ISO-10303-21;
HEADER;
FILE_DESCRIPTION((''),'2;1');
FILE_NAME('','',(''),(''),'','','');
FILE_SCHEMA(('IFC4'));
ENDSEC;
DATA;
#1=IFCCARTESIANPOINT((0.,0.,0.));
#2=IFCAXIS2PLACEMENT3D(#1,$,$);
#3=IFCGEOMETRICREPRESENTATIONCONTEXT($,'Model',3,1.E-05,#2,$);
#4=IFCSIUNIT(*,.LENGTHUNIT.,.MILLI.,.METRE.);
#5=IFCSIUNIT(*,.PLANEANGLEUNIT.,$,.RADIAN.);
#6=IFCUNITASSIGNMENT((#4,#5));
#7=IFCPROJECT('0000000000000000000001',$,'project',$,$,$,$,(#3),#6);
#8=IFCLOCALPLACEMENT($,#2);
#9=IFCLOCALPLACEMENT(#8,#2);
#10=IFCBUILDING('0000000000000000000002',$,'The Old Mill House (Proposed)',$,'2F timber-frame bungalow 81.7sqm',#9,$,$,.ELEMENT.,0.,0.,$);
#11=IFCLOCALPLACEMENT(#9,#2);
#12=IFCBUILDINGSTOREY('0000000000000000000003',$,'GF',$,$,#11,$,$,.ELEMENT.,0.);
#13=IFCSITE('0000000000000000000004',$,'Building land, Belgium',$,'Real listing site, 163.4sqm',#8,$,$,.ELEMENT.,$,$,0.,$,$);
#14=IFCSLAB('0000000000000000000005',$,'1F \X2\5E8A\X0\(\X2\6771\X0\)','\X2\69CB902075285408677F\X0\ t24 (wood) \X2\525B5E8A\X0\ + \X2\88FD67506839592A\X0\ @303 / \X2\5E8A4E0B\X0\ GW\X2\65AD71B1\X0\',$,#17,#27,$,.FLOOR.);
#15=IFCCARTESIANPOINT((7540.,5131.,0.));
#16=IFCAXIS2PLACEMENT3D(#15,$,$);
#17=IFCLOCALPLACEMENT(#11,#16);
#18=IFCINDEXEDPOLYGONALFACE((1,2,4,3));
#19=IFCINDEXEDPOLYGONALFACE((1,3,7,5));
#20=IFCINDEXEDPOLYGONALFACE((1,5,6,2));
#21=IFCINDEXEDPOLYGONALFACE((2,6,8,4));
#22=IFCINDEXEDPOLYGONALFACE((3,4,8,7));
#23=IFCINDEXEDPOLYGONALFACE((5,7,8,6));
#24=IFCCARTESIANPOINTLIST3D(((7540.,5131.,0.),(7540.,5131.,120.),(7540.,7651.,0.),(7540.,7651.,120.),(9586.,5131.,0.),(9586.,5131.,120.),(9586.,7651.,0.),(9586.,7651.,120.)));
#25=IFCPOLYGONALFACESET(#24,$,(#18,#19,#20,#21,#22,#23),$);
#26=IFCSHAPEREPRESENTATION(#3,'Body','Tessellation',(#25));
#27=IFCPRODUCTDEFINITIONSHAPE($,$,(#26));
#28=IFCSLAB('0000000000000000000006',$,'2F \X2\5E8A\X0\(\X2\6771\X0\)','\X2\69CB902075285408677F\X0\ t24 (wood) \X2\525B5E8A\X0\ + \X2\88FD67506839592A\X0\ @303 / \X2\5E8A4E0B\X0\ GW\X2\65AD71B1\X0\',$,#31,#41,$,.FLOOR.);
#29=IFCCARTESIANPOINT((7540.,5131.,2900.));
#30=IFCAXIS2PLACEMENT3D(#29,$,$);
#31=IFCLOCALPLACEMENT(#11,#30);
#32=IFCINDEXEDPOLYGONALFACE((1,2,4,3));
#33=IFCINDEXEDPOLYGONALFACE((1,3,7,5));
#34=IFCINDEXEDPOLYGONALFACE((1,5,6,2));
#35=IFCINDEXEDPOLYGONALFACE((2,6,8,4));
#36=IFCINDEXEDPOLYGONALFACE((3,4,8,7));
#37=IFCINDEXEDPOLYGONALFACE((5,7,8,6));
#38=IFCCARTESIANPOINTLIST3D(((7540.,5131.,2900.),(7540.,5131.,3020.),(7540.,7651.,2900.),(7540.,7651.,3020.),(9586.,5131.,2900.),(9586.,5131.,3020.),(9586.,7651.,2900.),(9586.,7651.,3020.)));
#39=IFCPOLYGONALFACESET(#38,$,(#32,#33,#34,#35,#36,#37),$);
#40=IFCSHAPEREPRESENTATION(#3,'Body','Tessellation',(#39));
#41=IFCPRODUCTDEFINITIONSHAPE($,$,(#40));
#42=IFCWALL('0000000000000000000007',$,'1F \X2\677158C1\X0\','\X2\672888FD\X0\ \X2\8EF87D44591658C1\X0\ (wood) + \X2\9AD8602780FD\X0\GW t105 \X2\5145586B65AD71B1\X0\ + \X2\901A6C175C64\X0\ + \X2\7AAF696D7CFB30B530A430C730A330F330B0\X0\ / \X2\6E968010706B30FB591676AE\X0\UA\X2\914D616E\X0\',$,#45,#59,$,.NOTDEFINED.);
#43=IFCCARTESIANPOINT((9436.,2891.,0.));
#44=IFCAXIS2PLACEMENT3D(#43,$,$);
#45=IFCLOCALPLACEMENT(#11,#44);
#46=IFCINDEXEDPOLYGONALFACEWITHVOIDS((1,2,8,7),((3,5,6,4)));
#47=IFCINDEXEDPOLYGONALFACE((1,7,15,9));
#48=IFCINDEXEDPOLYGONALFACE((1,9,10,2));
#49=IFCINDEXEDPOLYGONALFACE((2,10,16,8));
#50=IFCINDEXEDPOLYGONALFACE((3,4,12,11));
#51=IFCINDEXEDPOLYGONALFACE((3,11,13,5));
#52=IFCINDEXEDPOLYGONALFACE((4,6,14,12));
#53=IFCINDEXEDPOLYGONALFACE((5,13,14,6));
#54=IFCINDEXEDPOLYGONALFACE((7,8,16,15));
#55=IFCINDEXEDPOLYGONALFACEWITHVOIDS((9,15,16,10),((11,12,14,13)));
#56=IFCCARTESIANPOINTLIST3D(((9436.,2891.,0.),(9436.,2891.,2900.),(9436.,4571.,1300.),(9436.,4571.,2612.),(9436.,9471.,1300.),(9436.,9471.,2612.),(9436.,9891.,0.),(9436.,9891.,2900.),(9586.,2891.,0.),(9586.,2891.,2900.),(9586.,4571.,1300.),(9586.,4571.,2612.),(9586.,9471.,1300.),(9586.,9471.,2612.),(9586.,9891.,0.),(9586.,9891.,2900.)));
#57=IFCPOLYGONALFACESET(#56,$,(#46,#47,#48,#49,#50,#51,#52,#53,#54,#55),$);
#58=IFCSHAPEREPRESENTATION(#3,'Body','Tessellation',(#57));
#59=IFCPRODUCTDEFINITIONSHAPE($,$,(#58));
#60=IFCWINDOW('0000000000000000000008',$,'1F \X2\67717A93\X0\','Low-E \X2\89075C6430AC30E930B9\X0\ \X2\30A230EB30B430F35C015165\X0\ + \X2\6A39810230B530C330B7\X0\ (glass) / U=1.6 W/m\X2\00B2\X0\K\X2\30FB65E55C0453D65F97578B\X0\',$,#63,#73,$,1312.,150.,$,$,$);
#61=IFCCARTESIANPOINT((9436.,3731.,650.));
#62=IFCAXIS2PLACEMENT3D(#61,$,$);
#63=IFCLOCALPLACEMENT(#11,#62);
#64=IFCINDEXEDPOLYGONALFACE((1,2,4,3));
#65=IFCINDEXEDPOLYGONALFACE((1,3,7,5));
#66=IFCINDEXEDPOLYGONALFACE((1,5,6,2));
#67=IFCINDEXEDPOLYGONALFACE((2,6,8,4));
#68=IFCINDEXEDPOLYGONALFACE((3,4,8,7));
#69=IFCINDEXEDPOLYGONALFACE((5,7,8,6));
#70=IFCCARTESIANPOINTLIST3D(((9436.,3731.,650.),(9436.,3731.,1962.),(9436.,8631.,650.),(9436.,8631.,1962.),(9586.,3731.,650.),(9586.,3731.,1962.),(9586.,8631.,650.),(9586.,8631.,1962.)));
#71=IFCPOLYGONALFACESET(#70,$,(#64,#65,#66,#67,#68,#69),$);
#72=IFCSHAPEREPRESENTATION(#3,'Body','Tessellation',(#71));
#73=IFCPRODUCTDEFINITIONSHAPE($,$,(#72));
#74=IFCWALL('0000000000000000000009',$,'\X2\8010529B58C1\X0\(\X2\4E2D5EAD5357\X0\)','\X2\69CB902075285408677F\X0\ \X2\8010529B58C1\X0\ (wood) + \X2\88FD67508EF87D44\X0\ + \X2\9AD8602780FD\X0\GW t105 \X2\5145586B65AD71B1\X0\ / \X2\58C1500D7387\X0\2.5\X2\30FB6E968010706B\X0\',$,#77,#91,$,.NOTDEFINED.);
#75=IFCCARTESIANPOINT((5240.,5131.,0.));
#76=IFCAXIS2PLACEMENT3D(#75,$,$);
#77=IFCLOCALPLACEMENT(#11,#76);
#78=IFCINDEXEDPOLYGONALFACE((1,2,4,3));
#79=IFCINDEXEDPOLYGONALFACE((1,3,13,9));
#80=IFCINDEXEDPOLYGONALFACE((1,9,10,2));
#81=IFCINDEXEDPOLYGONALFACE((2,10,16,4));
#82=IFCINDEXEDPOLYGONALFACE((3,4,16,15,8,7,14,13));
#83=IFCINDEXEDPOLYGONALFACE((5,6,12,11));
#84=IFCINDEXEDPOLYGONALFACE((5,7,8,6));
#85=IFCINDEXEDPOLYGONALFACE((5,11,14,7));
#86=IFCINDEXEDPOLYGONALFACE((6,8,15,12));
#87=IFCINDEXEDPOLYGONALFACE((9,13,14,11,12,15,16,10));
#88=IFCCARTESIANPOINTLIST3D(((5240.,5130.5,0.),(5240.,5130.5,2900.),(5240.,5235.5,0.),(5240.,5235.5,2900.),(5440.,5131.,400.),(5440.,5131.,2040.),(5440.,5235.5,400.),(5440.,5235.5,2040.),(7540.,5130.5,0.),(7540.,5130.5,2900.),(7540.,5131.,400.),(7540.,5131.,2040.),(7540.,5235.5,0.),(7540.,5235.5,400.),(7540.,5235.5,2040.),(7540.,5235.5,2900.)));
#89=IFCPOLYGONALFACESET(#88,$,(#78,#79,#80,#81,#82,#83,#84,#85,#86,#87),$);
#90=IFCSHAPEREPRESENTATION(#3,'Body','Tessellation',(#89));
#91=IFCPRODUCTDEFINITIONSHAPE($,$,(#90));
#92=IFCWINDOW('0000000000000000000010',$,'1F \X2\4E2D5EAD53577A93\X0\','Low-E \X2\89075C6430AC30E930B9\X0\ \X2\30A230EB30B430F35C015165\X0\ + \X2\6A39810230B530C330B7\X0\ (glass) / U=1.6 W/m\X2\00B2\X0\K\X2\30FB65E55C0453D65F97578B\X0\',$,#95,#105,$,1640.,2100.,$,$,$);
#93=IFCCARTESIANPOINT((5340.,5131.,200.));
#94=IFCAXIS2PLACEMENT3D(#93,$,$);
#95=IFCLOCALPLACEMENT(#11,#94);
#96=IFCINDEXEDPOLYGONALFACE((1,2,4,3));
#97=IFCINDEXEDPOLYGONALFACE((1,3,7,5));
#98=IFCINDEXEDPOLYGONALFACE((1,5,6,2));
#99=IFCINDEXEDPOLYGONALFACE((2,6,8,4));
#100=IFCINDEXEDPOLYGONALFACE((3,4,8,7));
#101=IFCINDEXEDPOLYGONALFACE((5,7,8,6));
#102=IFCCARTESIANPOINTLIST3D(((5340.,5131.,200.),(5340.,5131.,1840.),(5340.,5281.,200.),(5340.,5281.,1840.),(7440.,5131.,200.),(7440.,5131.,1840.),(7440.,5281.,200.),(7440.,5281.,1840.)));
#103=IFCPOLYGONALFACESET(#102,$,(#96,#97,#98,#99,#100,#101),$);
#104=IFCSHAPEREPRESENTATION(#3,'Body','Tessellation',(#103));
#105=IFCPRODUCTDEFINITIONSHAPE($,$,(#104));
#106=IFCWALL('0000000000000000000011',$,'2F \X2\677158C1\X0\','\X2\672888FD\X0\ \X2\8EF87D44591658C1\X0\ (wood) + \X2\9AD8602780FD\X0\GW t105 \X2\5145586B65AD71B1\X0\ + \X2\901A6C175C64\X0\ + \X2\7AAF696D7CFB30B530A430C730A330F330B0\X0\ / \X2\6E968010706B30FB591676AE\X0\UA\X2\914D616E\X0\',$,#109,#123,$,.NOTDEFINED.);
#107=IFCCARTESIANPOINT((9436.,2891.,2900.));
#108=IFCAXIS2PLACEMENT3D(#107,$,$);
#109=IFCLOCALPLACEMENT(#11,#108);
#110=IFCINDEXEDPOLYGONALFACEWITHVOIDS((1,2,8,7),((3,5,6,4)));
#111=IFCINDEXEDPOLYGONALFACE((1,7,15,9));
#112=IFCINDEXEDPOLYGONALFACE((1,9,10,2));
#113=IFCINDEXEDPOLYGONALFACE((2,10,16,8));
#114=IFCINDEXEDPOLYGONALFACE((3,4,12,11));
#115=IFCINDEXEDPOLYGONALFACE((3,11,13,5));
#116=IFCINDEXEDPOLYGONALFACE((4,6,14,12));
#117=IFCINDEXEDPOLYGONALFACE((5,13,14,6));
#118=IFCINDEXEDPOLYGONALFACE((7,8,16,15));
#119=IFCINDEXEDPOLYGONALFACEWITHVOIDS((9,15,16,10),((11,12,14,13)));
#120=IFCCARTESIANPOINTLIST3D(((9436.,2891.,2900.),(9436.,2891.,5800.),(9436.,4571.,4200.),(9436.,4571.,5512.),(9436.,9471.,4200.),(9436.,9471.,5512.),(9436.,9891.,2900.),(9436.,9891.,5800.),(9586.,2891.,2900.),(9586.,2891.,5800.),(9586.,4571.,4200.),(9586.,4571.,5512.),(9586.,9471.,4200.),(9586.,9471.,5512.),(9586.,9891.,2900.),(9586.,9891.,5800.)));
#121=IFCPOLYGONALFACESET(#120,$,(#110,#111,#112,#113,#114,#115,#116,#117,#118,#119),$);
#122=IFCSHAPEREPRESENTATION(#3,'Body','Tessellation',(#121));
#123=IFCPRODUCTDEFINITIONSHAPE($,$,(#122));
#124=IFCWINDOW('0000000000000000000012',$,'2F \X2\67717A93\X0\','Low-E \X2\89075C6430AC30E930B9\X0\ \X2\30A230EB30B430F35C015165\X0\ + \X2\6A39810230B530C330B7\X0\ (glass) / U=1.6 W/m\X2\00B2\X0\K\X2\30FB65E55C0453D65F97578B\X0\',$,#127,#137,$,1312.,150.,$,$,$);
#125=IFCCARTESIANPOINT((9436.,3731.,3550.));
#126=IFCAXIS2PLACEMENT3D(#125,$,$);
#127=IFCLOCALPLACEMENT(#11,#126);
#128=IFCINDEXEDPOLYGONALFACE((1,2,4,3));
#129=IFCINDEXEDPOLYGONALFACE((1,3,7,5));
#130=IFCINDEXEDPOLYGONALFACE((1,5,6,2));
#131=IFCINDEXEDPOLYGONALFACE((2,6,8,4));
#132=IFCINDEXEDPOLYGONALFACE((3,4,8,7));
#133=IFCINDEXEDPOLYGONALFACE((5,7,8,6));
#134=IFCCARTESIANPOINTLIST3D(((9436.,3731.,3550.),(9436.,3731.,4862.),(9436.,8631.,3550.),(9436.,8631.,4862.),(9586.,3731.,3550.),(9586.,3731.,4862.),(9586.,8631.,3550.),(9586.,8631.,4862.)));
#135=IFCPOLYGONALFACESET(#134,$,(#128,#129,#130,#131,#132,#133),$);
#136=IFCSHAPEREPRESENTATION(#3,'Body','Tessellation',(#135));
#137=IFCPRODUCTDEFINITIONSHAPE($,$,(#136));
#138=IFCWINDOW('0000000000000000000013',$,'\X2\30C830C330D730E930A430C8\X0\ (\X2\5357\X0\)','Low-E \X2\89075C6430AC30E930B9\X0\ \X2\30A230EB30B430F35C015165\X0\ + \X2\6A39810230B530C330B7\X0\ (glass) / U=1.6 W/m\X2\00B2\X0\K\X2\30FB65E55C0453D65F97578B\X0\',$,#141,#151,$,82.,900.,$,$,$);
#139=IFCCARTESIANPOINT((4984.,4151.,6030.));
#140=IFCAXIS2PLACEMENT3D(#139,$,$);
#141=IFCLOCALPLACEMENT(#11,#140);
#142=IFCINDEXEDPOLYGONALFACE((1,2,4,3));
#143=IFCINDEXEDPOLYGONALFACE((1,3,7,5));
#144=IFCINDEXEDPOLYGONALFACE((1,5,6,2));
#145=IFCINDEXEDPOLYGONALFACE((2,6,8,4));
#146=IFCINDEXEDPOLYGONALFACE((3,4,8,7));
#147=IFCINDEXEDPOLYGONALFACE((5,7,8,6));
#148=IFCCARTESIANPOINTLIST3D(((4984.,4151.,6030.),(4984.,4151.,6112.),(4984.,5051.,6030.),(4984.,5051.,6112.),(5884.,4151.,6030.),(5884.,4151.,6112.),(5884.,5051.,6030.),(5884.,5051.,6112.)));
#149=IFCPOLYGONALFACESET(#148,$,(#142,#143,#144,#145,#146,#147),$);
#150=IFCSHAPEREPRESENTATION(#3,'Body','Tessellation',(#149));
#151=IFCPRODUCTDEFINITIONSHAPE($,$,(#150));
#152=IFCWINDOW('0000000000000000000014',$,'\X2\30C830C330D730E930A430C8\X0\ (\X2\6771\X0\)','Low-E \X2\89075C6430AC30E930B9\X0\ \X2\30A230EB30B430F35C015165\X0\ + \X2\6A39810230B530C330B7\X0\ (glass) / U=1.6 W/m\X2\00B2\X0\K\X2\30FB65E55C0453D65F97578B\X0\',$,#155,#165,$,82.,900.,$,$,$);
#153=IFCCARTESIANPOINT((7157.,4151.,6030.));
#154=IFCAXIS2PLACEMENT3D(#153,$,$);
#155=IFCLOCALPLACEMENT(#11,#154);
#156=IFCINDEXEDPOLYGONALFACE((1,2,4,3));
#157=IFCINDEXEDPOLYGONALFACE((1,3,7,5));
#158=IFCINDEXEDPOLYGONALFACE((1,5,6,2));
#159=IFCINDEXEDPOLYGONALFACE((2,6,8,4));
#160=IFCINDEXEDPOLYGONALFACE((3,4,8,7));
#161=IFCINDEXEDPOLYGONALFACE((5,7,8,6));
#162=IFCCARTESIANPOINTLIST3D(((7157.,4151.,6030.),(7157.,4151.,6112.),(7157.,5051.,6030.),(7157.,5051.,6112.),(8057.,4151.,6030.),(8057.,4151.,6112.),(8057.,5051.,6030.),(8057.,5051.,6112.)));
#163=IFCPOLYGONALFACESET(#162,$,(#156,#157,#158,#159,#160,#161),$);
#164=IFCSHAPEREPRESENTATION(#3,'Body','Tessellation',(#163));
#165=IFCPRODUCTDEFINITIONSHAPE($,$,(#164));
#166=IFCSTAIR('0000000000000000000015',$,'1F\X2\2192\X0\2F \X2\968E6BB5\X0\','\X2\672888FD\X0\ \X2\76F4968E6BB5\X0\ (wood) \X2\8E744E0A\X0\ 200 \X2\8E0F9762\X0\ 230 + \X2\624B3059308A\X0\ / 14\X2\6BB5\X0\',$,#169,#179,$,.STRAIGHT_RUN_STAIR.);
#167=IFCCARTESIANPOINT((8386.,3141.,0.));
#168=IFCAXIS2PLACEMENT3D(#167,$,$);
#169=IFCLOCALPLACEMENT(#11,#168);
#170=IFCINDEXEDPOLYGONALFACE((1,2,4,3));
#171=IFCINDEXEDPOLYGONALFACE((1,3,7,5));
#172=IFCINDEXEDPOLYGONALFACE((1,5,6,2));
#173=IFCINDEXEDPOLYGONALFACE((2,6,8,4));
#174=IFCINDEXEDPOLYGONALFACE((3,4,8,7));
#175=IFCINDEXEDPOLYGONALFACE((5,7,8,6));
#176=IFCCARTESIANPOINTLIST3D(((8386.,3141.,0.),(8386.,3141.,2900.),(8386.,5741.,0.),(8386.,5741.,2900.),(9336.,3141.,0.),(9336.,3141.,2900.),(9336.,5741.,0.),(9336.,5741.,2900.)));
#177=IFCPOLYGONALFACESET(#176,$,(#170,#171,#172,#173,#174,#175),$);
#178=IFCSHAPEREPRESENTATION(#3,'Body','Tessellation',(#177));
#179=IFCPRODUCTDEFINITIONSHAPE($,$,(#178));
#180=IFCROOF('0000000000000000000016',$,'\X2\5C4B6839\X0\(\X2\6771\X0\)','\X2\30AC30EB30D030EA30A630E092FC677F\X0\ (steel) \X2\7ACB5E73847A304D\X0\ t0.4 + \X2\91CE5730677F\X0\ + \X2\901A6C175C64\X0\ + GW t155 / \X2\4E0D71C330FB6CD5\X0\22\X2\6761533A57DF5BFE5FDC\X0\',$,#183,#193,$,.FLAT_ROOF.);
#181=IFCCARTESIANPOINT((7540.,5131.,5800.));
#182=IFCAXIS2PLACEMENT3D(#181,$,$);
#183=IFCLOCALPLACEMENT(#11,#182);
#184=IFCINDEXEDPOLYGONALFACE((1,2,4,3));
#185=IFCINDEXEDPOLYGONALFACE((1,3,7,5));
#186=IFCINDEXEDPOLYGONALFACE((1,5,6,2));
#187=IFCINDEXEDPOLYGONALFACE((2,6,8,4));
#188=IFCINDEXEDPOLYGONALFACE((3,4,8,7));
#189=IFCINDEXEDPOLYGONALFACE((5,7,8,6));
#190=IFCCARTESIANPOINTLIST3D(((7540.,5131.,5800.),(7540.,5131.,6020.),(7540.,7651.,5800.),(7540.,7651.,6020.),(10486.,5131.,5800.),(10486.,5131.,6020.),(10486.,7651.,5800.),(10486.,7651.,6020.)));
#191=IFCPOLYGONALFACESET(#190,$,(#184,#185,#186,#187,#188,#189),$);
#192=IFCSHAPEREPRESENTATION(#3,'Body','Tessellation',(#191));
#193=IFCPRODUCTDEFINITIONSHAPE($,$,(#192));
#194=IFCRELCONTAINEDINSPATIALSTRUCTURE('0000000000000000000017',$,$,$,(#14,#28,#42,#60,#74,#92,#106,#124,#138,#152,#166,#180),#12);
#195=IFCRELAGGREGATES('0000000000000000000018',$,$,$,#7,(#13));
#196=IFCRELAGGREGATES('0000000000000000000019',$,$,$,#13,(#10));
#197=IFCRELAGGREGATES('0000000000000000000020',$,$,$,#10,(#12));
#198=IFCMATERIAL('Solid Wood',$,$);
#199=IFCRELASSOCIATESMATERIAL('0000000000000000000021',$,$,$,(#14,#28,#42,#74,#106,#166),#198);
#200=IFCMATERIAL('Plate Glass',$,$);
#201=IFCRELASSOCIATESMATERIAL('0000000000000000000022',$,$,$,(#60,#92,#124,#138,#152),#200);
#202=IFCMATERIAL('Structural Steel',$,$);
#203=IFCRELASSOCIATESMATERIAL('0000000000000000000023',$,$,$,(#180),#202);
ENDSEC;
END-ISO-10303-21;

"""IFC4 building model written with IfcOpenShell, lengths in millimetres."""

from ifc_helpers import new_model, si_unit, frame, frame_2d, origin, place, context, project, spatial, rectangle, extrude, material, element, fill, save


model = new_model("IFC4")

# Units and contexts
model_context = context("Model", 3, precision=1e-05, world=origin())
ifc_project = project(units=[si_unit("LENGTHUNIT", "METRE", prefix="MILLI"), si_unit("PLANEANGLEUNIT", "RADIAN")], contexts=[model_context])

# Site, building, storey
site_placement = place(None, origin())
site = spatial("IfcSite", under=ifc_project, at=site_placement, Name="Building land, Belgium", ObjectType="Real listing site, 163.4sqm", CompositionType="ELEMENT", RefElevation=0.0)
building_placement = place(site_placement, origin())
building = spatial("IfcBuilding", under=site, at=building_placement, Name="The Old Mill House (Proposed)", ObjectType="2F timber-frame bungalow 81.7sqm", CompositionType="ELEMENT", ElevationOfRefHeight=0.0, ElevationOfTerrain=0.0)
storey_placement = place(building_placement, origin())
storey = spatial("IfcBuildingStorey", under=building, at=storey_placement, Name="GF", CompositionType="ELEMENT", Elevation=0.0)

# Slabs
ifc_material_1 = material(Name="Solid Wood")
slab_1_placement = place(storey_placement, frame((7540.0, 5131.0, 0.0)))
element("IfcSlab", 1, at=slab_1_placement, inside=storey, material=ifc_material_1, Name="1F 床(東)", Description="構造用合板 t24 (wood) 剛床 + 製材根太 @303 / 床下 GW断熱", PredefinedType="FLOOR", context=model_context, shape_type="SweptSolid", body=[
    extrude(rectangle(XDim=2046.0, YDim=2520.0, at=frame_2d((1023.0, 1260.0))), frame((7540.0, 5131.0, 0.0)), (0.0, 0.0, 1.0), 120.0),
])
slab_2_placement = place(storey_placement, frame((7540.0, 5131.0, 2900.0)))
element("IfcSlab", 2, at=slab_2_placement, inside=storey, material=ifc_material_1, Name="2F 床(東)", Description="構造用合板 t24 (wood) 剛床 + 製材根太 @303 / 床下 GW断熱", PredefinedType="FLOOR", context=model_context, shape_type="SweptSolid", body=[
    extrude(rectangle(XDim=2046.0, YDim=2520.0, at=frame_2d((1023.0, 1260.0))), frame((7540.0, 5131.0, 2900.0)), (0.0, 0.0, 1.0), 120.0),
])

# Walls, openings, windows
wall_1_placement = place(storey_placement, frame((9436.0, 2891.0, 0.0)))
wall_1 = element("IfcWall", 3, at=wall_1_placement, inside=storey, material=ifc_material_1, Name="1F 東壁", Description="木製 軸組外壁 (wood) + 高性能GW t105 充填断熱 + 通気層 + 窯業系サイディング / 準耐火・外皮UA配慮", PredefinedType="NOTDEFINED", context=model_context, shape_type="SweptSolid", body=[
    extrude(rectangle(XDim=150.0, YDim=7000.0, at=frame_2d((75.0, 3500.0))), frame((9436.0, 2891.0, 0.0)), (0.0, 0.0, 1.0), 2900.0),
])
opening_1_placement = place(storey_placement, frame((9436.0, 3731.0, 650.0)))
opening_1 = element("IfcOpeningElement", 4, at=opening_1_placement, cuts=wall_1, PredefinedType="NOTDEFINED", context=model_context, shape_type="SweptSolid", body=[
    extrude(rectangle(XDim=150.0, YDim=4900.0, at=frame_2d((75.0, 2450.0))), frame((9436.0, 3731.0, 650.0)), (0.0, 0.0, 1.0), 1312.0),
])
ifc_material_2 = material(Name="Plate Glass")
window_1_placement = place(storey_placement, frame((9436.0, 3731.0, 650.0)))
window_1 = element("IfcWindow", 5, at=window_1_placement, inside=storey, material=ifc_material_2, Name="1F 東窓", Description="Low-E 複層ガラス アルゴン封入 + 樹脂サッシ (glass) / U=1.6 W/m²K・日射取得型", OverallHeight=1312.0, OverallWidth=150.0, context=model_context, shape_type="SweptSolid", body=[
    extrude(rectangle(XDim=150.0, YDim=4900.0, at=frame_2d((75.0, 2450.0))), frame((9436.0, 3731.0, 650.0)), (0.0, 0.0, 1.0), 1312.0),
])
fill(opening_1, window_1)
wall_2_placement = place(storey_placement, frame((5240.0, 5131.0, 0.0)))
wall_2 = element("IfcWall", 6, at=wall_2_placement, inside=storey, material=ifc_material_1, Name="耐力壁(中庭南)", Description="構造用合板 耐力壁 (wood) + 製材軸組 + 高性能GW t105 充填断熱 / 壁倍率2.5・準耐火", PredefinedType="NOTDEFINED", context=model_context, shape_type="SweptSolid", body=[
    extrude(rectangle(XDim=2300.0, YDim=105.0, at=frame_2d((1150.0, 52.0))), frame((5240.0, 5131.0, 0.0)), (0.0, 0.0, 1.0), 2900.0),
])
opening_2_placement = place(storey_placement, frame((5340.0, 5131.0, 200.0)))
opening_2 = element("IfcOpeningElement", 7, at=opening_2_placement, cuts=wall_2, PredefinedType="NOTDEFINED", context=model_context, shape_type="SweptSolid", body=[
    extrude(rectangle(XDim=2100.0, YDim=150.0, at=frame_2d((1050.0, 75.0))), frame((5340.0, 5131.0, 200.0)), (0.0, 0.0, 1.0), 1640.0),
])
window_2_placement = place(storey_placement, frame((5340.0, 5131.0, 200.0)))
window_2 = element("IfcWindow", 8, at=window_2_placement, inside=storey, material=ifc_material_2, Name="1F 中庭南窓", Description="Low-E 複層ガラス アルゴン封入 + 樹脂サッシ (glass) / U=1.6 W/m²K・日射取得型", OverallHeight=1640.0, OverallWidth=2100.0, context=model_context, shape_type="SweptSolid", body=[
    extrude(rectangle(XDim=2100.0, YDim=150.0, at=frame_2d((1050.0, 75.0))), frame((5340.0, 5131.0, 200.0)), (0.0, 0.0, 1.0), 1640.0),
])
fill(opening_2, window_2)

# Wall, opening, window
wall_3_placement = place(storey_placement, frame((9436.0, 2891.0, 2900.0)))
wall_3 = element("IfcWall", 9, at=wall_3_placement, inside=storey, material=ifc_material_1, Name="2F 東壁", Description="木製 軸組外壁 (wood) + 高性能GW t105 充填断熱 + 通気層 + 窯業系サイディング / 準耐火・外皮UA配慮", PredefinedType="NOTDEFINED", context=model_context, shape_type="SweptSolid", body=[
    extrude(rectangle(XDim=150.0, YDim=7000.0, at=frame_2d((75.0, 3500.0))), frame((9436.0, 2891.0, 2900.0)), (0.0, 0.0, 1.0), 2900.0),
])
opening_3_placement = place(storey_placement, frame((9436.0, 3731.0, 3550.0)))
opening_3 = element("IfcOpeningElement", 10, at=opening_3_placement, cuts=wall_3, PredefinedType="NOTDEFINED", context=model_context, shape_type="SweptSolid", body=[
    extrude(rectangle(XDim=150.0, YDim=4900.0, at=frame_2d((75.0, 2450.0))), frame((9436.0, 3731.0, 3550.0)), (0.0, 0.0, 1.0), 1312.0),
])
window_3_placement = place(storey_placement, frame((9436.0, 3731.0, 3550.0)))
window_3 = element("IfcWindow", 11, at=window_3_placement, inside=storey, material=ifc_material_2, Name="2F 東窓", Description="Low-E 複層ガラス アルゴン封入 + 樹脂サッシ (glass) / U=1.6 W/m²K・日射取得型", OverallHeight=1312.0, OverallWidth=150.0, context=model_context, shape_type="SweptSolid", body=[
    extrude(rectangle(XDim=150.0, YDim=4900.0, at=frame_2d((75.0, 2450.0))), frame((9436.0, 3731.0, 3550.0)), (0.0, 0.0, 1.0), 1312.0),
])
fill(opening_3, window_3)

# Windows
window_4_placement = place(storey_placement, frame((4984.0, 4151.0, 6030.0)))
element("IfcWindow", 12, at=window_4_placement, inside=storey, material=ifc_material_2, Name="トップライト (南)", Description="Low-E 複層ガラス アルゴン封入 + 樹脂サッシ (glass) / U=1.6 W/m²K・日射取得型", OverallHeight=82.0, OverallWidth=900.0, context=model_context, shape_type="SweptSolid", body=[
    extrude(rectangle(XDim=900.0, YDim=900.0, at=frame_2d((450.0, 450.0))), frame((4984.0, 4151.0, 6030.0)), (0.0, 0.0, 1.0), 82.0),
])
window_5_placement = place(storey_placement, frame((7157.0, 4151.0, 6030.0)))
element("IfcWindow", 13, at=window_5_placement, inside=storey, material=ifc_material_2, Name="トップライト (東)", Description="Low-E 複層ガラス アルゴン封入 + 樹脂サッシ (glass) / U=1.6 W/m²K・日射取得型", OverallHeight=82.0, OverallWidth=900.0, context=model_context, shape_type="SweptSolid", body=[
    extrude(rectangle(XDim=900.0, YDim=900.0, at=frame_2d((450.0, 450.0))), frame((7157.0, 4151.0, 6030.0)), (0.0, 0.0, 1.0), 82.0),
])

# Stair
stair_placement = place(storey_placement, frame((8386.0, 3141.0, 0.0)))
element("IfcStair", 14, at=stair_placement, inside=storey, material=ifc_material_1, Name="1F→2F 階段", Description="木製 直階段 (wood) 蹴上 200 踏面 230 + 手すり / 14段", PredefinedType="STRAIGHT_RUN_STAIR", context=model_context, shape_type="SweptSolid", body=[
    extrude(rectangle(XDim=950.0, YDim=2600.0, at=frame_2d((475.0, 1300.0))), frame((8386.0, 3141.0, 0.0)), (0.0, 0.0, 1.0), 2900.0),
])

# Roof
ifc_material_3 = material(Name="Structural Steel")
roof_placement = place(storey_placement, frame((7540.0, 5131.0, 5800.0)))
element("IfcRoof", 15, at=roof_placement, inside=storey, material=ifc_material_3, Name="屋根(東)", Description="ガルバリウム鋼板 (steel) 立平葺き t0.4 + 野地板 + 通気層 + GW t155 / 不燃・法22条区域対応", PredefinedType="FLAT_ROOF", context=model_context, shape_type="SweptSolid", body=[
    extrude(rectangle(XDim=2946.0, YDim=2520.0, at=frame_2d((1473.0, 1260.0))), frame((7540.0, 5131.0, 5800.0)), (0.0, 0.0, 1.0), 220.0),
])

save(model, "model.ifc")
